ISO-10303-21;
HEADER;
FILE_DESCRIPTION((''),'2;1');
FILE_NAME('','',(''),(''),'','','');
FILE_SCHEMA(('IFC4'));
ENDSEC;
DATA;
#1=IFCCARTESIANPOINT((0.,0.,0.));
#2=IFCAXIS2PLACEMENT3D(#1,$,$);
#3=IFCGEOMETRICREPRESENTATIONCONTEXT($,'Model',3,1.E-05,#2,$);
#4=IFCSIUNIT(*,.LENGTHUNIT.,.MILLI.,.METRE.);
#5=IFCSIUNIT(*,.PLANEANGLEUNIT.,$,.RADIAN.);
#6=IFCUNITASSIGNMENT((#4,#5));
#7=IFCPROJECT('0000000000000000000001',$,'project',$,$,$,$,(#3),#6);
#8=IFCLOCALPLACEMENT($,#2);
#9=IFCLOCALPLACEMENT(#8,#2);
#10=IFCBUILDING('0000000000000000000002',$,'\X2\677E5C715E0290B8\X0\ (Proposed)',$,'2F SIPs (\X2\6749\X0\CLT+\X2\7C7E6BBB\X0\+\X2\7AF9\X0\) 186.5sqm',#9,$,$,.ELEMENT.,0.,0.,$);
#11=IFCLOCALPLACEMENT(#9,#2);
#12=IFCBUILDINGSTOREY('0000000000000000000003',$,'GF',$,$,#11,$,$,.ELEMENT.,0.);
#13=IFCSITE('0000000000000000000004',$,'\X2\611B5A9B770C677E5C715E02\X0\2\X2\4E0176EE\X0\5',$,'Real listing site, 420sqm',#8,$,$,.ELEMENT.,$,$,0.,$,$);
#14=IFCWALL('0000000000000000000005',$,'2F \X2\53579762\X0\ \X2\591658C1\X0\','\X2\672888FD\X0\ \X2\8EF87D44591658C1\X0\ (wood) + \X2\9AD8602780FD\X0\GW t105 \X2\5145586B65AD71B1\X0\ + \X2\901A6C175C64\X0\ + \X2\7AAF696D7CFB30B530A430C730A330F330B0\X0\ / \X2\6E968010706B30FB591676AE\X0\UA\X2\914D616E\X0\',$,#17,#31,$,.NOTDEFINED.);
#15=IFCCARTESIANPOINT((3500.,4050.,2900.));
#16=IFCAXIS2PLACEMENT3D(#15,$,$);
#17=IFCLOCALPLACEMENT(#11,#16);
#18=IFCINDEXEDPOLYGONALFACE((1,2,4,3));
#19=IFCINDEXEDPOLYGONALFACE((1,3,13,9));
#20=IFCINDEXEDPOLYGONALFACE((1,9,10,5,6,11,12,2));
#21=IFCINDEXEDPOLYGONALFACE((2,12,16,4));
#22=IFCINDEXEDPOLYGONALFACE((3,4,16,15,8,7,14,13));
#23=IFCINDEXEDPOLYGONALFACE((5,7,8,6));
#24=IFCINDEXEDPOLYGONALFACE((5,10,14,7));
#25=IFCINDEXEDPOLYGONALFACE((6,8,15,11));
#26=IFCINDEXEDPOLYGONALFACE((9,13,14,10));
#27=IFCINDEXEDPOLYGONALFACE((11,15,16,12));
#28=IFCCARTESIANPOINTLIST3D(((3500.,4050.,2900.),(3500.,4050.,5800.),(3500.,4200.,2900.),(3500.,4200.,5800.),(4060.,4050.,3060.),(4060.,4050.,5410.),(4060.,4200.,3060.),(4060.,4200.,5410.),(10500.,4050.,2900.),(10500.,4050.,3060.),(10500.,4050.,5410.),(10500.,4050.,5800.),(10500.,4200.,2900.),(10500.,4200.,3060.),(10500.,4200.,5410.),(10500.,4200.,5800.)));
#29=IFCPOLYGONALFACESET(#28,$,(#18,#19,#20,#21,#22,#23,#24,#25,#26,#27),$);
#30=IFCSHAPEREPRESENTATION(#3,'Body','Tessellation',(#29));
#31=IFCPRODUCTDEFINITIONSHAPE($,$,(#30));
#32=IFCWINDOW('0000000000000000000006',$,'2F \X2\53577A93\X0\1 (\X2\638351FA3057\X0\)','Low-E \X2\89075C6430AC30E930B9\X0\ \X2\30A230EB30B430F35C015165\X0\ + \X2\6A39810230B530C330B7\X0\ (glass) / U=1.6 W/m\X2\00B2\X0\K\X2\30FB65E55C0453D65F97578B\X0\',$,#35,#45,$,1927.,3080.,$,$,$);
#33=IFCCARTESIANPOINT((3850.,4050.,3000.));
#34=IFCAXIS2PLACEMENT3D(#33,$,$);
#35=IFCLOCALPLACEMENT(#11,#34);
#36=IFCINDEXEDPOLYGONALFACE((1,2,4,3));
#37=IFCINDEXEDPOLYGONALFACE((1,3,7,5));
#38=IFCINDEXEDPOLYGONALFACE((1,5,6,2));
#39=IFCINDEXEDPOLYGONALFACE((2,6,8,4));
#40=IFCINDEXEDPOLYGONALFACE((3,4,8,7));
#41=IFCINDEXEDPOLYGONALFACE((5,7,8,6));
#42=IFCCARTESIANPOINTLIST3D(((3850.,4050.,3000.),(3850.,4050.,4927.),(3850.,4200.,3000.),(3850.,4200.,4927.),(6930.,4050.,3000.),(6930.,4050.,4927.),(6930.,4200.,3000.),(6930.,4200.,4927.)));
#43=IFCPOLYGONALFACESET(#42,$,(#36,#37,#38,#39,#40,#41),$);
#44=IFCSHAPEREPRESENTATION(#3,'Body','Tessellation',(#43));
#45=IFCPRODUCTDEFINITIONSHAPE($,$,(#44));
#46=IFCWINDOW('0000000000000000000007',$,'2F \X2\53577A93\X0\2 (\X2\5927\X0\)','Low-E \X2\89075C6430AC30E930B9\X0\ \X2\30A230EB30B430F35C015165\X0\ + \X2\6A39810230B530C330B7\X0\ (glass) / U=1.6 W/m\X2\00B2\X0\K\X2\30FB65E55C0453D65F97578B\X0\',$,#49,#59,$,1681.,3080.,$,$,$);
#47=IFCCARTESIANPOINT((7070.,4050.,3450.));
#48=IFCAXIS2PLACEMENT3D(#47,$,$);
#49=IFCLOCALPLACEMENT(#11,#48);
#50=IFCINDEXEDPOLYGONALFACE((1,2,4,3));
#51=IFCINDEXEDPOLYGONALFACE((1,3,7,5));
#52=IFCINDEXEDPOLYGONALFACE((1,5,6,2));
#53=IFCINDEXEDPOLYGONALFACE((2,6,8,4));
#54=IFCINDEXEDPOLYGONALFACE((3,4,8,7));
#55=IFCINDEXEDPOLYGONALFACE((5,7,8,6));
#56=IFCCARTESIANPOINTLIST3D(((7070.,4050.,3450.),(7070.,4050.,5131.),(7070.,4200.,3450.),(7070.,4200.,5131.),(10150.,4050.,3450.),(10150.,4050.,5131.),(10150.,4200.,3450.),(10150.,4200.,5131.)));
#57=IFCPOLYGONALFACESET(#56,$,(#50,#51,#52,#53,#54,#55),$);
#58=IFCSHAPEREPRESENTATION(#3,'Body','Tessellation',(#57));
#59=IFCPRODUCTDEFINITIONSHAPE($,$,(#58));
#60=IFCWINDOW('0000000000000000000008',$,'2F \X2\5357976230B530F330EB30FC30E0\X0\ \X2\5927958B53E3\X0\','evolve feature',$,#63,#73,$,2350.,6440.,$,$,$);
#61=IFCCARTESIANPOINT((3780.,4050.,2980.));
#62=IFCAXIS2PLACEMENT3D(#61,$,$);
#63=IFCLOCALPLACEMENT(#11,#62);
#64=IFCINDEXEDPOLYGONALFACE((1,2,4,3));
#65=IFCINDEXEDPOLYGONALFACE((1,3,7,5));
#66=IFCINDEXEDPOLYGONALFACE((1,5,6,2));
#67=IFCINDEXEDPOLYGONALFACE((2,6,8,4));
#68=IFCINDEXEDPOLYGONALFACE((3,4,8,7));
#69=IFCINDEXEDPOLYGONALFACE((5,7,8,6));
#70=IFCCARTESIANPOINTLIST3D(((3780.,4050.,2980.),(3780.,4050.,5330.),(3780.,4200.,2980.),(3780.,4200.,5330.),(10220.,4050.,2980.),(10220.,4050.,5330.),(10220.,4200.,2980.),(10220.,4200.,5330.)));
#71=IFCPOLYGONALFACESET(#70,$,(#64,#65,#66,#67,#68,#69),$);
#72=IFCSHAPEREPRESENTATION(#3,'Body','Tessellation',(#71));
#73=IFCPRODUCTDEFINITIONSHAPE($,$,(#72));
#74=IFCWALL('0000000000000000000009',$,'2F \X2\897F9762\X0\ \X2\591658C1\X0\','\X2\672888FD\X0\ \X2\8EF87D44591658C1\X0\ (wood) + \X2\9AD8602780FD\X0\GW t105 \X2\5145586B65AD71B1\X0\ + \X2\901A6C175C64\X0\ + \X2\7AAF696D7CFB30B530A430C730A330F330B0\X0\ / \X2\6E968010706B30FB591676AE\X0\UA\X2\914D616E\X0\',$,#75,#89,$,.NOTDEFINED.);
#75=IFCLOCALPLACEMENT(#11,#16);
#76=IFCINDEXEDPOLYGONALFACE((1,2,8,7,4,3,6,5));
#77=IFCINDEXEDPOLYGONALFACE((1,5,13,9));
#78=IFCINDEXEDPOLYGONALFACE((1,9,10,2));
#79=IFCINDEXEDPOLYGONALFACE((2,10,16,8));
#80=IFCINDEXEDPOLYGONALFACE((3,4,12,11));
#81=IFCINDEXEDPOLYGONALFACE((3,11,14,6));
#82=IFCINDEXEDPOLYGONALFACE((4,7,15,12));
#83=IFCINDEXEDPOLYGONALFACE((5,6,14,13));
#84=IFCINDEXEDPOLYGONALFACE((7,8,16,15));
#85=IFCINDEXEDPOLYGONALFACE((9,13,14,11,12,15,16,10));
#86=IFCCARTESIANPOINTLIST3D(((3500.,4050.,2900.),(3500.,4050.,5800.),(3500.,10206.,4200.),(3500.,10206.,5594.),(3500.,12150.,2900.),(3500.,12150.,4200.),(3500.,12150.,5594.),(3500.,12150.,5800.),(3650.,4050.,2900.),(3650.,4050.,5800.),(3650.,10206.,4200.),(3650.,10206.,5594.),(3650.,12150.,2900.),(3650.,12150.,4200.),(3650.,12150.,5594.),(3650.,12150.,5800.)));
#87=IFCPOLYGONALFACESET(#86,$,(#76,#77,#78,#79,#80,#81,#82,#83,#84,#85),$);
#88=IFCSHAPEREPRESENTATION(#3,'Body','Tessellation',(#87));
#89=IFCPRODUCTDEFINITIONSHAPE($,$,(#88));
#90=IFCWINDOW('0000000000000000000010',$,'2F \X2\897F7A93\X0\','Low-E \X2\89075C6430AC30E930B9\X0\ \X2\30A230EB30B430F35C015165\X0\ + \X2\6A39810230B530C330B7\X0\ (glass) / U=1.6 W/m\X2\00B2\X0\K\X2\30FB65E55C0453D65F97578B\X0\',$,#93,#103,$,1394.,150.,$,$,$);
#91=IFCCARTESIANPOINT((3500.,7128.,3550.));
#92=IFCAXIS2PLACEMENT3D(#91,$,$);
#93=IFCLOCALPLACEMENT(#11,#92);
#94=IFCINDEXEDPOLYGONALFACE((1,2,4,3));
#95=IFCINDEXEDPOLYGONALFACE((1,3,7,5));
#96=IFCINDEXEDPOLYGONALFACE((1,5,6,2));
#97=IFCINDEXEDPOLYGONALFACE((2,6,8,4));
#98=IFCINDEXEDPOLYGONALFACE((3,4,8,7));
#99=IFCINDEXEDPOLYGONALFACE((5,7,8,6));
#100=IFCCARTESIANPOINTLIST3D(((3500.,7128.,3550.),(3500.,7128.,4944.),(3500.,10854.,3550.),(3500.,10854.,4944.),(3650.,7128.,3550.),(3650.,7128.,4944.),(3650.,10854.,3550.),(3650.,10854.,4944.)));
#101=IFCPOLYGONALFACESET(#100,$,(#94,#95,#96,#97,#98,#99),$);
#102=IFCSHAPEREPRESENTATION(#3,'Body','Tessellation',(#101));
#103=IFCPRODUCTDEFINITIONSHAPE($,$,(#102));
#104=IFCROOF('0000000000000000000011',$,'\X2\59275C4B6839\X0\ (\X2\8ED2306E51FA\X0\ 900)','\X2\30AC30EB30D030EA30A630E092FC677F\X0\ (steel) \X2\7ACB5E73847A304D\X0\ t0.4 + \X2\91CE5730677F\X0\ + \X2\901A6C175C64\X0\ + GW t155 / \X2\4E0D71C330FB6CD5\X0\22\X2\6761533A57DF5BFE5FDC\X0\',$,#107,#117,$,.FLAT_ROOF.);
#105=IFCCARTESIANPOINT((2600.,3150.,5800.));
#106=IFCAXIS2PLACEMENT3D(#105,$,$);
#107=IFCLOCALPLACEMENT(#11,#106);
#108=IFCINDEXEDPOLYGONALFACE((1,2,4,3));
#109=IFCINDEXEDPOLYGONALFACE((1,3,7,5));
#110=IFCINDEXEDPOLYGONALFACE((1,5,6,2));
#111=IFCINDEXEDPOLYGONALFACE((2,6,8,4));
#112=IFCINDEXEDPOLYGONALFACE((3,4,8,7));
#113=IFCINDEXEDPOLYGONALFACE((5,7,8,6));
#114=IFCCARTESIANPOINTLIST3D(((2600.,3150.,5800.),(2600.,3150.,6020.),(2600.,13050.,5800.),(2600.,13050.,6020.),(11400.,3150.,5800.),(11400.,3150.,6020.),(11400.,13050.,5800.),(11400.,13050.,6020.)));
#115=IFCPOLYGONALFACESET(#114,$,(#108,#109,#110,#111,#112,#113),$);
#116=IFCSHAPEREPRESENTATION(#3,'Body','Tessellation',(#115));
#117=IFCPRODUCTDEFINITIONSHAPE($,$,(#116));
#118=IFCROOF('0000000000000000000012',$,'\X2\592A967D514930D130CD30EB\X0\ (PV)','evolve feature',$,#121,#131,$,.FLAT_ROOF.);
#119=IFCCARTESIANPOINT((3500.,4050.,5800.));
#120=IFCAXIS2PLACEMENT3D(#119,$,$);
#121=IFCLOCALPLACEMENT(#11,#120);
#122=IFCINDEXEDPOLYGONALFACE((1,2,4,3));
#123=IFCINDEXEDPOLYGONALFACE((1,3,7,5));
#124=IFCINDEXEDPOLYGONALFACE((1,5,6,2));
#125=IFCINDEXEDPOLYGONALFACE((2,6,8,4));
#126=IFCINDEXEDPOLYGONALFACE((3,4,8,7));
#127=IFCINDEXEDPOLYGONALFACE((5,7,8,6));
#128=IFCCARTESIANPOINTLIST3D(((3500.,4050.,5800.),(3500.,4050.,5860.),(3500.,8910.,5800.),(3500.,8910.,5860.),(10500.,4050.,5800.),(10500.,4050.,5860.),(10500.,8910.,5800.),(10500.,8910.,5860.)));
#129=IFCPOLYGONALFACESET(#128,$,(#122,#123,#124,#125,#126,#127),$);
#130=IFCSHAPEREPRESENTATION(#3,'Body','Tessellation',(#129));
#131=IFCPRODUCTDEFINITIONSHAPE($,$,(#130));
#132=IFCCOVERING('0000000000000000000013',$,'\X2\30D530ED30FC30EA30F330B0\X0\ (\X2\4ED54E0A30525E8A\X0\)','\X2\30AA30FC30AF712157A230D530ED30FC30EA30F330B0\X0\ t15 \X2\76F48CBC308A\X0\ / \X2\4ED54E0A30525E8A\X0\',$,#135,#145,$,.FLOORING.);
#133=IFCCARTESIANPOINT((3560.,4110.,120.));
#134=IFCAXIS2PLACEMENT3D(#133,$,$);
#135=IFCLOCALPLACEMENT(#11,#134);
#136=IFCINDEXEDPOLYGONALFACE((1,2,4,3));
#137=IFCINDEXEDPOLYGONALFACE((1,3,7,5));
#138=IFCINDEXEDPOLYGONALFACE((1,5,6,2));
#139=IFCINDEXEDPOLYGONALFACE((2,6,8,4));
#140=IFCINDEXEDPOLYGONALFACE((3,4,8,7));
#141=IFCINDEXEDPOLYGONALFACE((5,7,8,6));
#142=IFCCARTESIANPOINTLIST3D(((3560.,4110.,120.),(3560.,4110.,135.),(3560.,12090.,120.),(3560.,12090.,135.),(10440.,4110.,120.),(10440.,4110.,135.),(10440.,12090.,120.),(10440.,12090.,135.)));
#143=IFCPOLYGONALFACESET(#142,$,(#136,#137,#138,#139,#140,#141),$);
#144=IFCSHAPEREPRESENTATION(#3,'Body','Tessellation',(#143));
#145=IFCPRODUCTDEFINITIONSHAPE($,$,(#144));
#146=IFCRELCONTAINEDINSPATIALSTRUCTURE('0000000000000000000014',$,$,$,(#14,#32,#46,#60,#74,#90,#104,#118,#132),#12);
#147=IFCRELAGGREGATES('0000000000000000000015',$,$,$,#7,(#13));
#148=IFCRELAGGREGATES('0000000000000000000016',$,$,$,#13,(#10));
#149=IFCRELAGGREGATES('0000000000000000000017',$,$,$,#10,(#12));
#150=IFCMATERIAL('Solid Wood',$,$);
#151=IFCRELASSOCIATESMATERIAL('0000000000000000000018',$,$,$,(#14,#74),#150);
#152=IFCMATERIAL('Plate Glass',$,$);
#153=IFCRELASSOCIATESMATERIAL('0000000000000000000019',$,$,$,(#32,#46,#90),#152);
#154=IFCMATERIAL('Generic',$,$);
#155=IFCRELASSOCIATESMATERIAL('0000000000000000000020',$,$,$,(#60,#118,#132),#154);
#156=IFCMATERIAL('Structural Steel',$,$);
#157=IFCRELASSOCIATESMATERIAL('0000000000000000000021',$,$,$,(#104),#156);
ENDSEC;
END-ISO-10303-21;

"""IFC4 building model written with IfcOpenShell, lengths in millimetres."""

from ifc_helpers import new_model, si_unit, frame, frame_2d, origin, place, context, project, spatial, rectangle, extrude, material, element, fill, save


model = new_model("IFC4")

# Units and contexts
model_context = context("Model", 3, precision=1e-05, world=origin())
ifc_project = project(units=[si_unit("LENGTHUNIT", "METRE", prefix="MILLI"), si_unit("PLANEANGLEUNIT", "RADIAN")], contexts=[model_context])

# Site, building, storey
site_placement = place(None, origin())
site = spatial("IfcSite", under=ifc_project, at=site_placement, Name="愛媛県松山市2丁目5", ObjectType="Real listing site, 420sqm", CompositionType="ELEMENT", RefElevation=0.0)
building_placement = place(site_placement, origin())
building = spatial("IfcBuilding", under=site, at=building_placement, Name="松山市邸 (Proposed)", ObjectType="2F SIPs (杉CLT+籾殻+竹) 186.5sqm", CompositionType="ELEMENT", ElevationOfRefHeight=0.0, ElevationOfTerrain=0.0)
storey_placement = place(building_placement, origin())
storey = spatial("IfcBuildingStorey", under=building, at=storey_placement, Name="GF", CompositionType="ELEMENT", Elevation=0.0)

# Shared definitions
ifc_material_1 = material(Name="Solid Wood")
ifc_material_2 = material(Name="Generic")

# Shared definitions
ifc_material_3 = material(Name="Plate Glass")

# Wall, openings, windows
wall_1_placement = place(storey_placement, frame((3500.0, 4050.0, 2900.0)))
wall_1 = element("IfcWall", 1, at=wall_1_placement, inside=storey, material=ifc_material_1, Name="2F 南面 外壁", Description="木製 軸組外壁 (wood) + 高性能GW t105 充填断熱 + 通気層 + 窯業系サイディング / 準耐火・外皮UA配慮", PredefinedType="NOTDEFINED", context=model_context, shape_type="SweptSolid", body=[
    extrude(rectangle(XDim=7000.0, YDim=150.0, at=frame_2d((3500.0, 75.0))), frame((3500.0, 4050.0, 2900.0)), (0.0, 0.0, 1.0), 2900.0),
])
opening_1_placement = place(storey_placement, frame((3850.0, 4050.0, 3000.0)))
opening_1 = element("IfcOpeningElement", 2, at=opening_1_placement, cuts=wall_1, PredefinedType="NOTDEFINED", context=model_context, shape_type="SweptSolid", body=[
    extrude(rectangle(XDim=3080.0, YDim=150.0, at=frame_2d((1540.0, 75.0))), frame((3850.0, 4050.0, 3000.0)), (0.0, 0.0, 1.0), 1927.0),
])
opening_2_placement = place(storey_placement, frame((7070.0, 4050.0, 3450.0)))
opening_2 = element("IfcOpeningElement", 3, at=opening_2_placement, cuts=wall_1, PredefinedType="NOTDEFINED", context=model_context, shape_type="SweptSolid", body=[
    extrude(rectangle(XDim=3080.0, YDim=150.0, at=frame_2d((1540.0, 75.0))), frame((7070.0, 4050.0, 3450.0)), (0.0, 0.0, 1.0), 1681.0),
])
opening_3_placement = place(storey_placement, frame((3780.0, 4050.0, 2980.0)))
opening_3 = element("IfcOpeningElement", 4, at=opening_3_placement, cuts=wall_1, PredefinedType="NOTDEFINED", context=model_context, shape_type="SweptSolid", body=[
    extrude(rectangle(XDim=6440.0, YDim=150.0, at=frame_2d((3220.0, 75.0))), frame((3780.0, 4050.0, 2980.0)), (0.0, 0.0, 1.0), 2350.0),
])
window_1_placement = place(storey_placement, frame((3850.0, 4050.0, 3000.0)))
window_1 = element("IfcWindow", 5, at=window_1_placement, inside=storey, material=ifc_material_3, Name="2F 南窓1 (掃出し)", Description="Low-E 複層ガラス アルゴン封入 + 樹脂サッシ (glass) / U=1.6 W/m²K・日射取得型", OverallHeight=1927.0, OverallWidth=3080.0, context=model_context, shape_type="SweptSolid", body=[
    extrude(rectangle(XDim=3080.0, YDim=150.0, at=frame_2d((1540.0, 75.0))), frame((3850.0, 4050.0, 3000.0)), (0.0, 0.0, 1.0), 1927.0),
])
fill(opening_1, window_1)
window_2_placement = place(storey_placement, frame((7070.0, 4050.0, 3450.0)))
window_2 = element("IfcWindow", 6, at=window_2_placement, inside=storey, material=ifc_material_3, Name="2F 南窓2 (大)", Description="Low-E 複層ガラス アルゴン封入 + 樹脂サッシ (glass) / U=1.6 W/m²K・日射取得型", OverallHeight=1681.0, OverallWidth=3080.0, context=model_context, shape_type="SweptSolid", body=[
    extrude(rectangle(XDim=3080.0, YDim=150.0, at=frame_2d((1540.0, 75.0))), frame((7070.0, 4050.0, 3450.0)), (0.0, 0.0, 1.0), 1681.0),
])
fill(opening_2, window_2)
window_3_placement = place(storey_placement, frame((3780.0, 4050.0, 2980.0)))
window_3 = element("IfcWindow", 7, at=window_3_placement, inside=storey, material=ifc_material_2, Name="2F 南面サンルーム 大開口", Description="evolve feature", OverallHeight=2350.0, OverallWidth=6440.0, context=model_context, shape_type="SweptSolid", body=[
    extrude(rectangle(XDim=6440.0, YDim=150.0, at=frame_2d((3220.0, 75.0))), frame((3780.0, 4050.0, 2980.0)), (0.0, 0.0, 1.0), 2350.0),
])
fill(opening_3, window_3)

# Wall, opening, window
wall_2_placement = place(storey_placement, frame((3500.0, 4050.0, 2900.0)))
wall_2 = element("IfcWall", 8, at=wall_2_placement, inside=storey, material=ifc_material_1, Name="2F 西面 外壁", Description="木製 軸組外壁 (wood) + 高性能GW t105 充填断熱 + 通気層 + 窯業系サイディング / 準耐火・外皮UA配慮", PredefinedType="NOTDEFINED", context=model_context, shape_type="SweptSolid", body=[
    extrude(rectangle(XDim=150.0, YDim=8100.0, at=frame_2d((75.0, 4050.0))), frame((3500.0, 4050.0, 2900.0)), (0.0, 0.0, 1.0), 2900.0),
])
opening_4_placement = place(storey_placement, frame((3500.0, 7128.0, 3550.0)))
opening_4 = element("IfcOpeningElement", 9, at=opening_4_placement, cuts=wall_2, PredefinedType="NOTDEFINED", context=model_context, shape_type="SweptSolid", body=[
    extrude(rectangle(XDim=150.0, YDim=3726.0, at=frame_2d((75.0, 1863.0))), frame((3500.0, 7128.0, 3550.0)), (0.0, 0.0, 1.0), 1394.0),
])
window_4_placement = place(storey_placement, frame((3500.0, 7128.0, 3550.0)))
window_4 = element("IfcWindow", 10, at=window_4_placement, inside=storey, material=ifc_material_3, Name="2F 西窓", Description="Low-E 複層ガラス アルゴン封入 + 樹脂サッシ (glass) / U=1.6 W/m²K・日射取得型", OverallHeight=1394.0, OverallWidth=150.0, context=model_context, shape_type="SweptSolid", body=[
    extrude(rectangle(XDim=150.0, YDim=3726.0, at=frame_2d((75.0, 1863.0))), frame((3500.0, 7128.0, 3550.0)), (0.0, 0.0, 1.0), 1394.0),
])
fill(opening_4, window_4)

# Roofs
ifc_material_4 = material(Name="Structural Steel")
roof_1_placement = place(storey_placement, frame((2600.0, 3150.0, 5800.0)))
element("IfcRoof", 11, at=roof_1_placement, inside=storey, material=ifc_material_4, Name="大屋根 (軒の出 900)", Description="ガルバリウム鋼板 (steel) 立平葺き t0.4 + 野地板 + 通気層 + GW t155 / 不燃・法22条区域対応", PredefinedType="FLAT_ROOF", context=model_context, shape_type="SweptSolid", body=[
    extrude(rectangle(XDim=8800.0, YDim=9900.0, at=frame_2d((4400.0, 4950.0))), frame((2600.0, 3150.0, 5800.0)), (0.0, 0.0, 1.0), 220.0),
])
roof_2_placement = place(storey_placement, frame((3500.0, 4050.0, 5800.0)))
element("IfcRoof", 12, at=roof_2_placement, inside=storey, material=ifc_material_2, Name="太陽光パネル (PV)", Description="evolve feature", PredefinedType="FLAT_ROOF", context=model_context, shape_type="SweptSolid", body=[
    extrude(rectangle(XDim=7000.0, YDim=4860.0, at=frame_2d((3500.0, 2430.0))), frame((3500.0, 4050.0, 5800.0)), (0.0, 0.0, 1.0), 60.0),
])

# Covering
covering_placement = place(storey_placement, frame((3560.0, 4110.0, 120.0)))
element("IfcCovering", 13, at=covering_placement, inside=storey, material=ifc_material_2, Name="フローリング (仕上げ床)", Description="オーク無垢フローリング t15 直貼り / 仕上げ床", PredefinedType="FLOORING", context=model_context, shape_type="SweptSolid", body=[
    extrude(rectangle(XDim=6880.0, YDim=7980.0, at=frame_2d((3440.0, 3990.0))), frame((3560.0, 4110.0, 120.0)), (0.0, 0.0, 1.0), 15.0),
])

save(model, "model.ifc")
